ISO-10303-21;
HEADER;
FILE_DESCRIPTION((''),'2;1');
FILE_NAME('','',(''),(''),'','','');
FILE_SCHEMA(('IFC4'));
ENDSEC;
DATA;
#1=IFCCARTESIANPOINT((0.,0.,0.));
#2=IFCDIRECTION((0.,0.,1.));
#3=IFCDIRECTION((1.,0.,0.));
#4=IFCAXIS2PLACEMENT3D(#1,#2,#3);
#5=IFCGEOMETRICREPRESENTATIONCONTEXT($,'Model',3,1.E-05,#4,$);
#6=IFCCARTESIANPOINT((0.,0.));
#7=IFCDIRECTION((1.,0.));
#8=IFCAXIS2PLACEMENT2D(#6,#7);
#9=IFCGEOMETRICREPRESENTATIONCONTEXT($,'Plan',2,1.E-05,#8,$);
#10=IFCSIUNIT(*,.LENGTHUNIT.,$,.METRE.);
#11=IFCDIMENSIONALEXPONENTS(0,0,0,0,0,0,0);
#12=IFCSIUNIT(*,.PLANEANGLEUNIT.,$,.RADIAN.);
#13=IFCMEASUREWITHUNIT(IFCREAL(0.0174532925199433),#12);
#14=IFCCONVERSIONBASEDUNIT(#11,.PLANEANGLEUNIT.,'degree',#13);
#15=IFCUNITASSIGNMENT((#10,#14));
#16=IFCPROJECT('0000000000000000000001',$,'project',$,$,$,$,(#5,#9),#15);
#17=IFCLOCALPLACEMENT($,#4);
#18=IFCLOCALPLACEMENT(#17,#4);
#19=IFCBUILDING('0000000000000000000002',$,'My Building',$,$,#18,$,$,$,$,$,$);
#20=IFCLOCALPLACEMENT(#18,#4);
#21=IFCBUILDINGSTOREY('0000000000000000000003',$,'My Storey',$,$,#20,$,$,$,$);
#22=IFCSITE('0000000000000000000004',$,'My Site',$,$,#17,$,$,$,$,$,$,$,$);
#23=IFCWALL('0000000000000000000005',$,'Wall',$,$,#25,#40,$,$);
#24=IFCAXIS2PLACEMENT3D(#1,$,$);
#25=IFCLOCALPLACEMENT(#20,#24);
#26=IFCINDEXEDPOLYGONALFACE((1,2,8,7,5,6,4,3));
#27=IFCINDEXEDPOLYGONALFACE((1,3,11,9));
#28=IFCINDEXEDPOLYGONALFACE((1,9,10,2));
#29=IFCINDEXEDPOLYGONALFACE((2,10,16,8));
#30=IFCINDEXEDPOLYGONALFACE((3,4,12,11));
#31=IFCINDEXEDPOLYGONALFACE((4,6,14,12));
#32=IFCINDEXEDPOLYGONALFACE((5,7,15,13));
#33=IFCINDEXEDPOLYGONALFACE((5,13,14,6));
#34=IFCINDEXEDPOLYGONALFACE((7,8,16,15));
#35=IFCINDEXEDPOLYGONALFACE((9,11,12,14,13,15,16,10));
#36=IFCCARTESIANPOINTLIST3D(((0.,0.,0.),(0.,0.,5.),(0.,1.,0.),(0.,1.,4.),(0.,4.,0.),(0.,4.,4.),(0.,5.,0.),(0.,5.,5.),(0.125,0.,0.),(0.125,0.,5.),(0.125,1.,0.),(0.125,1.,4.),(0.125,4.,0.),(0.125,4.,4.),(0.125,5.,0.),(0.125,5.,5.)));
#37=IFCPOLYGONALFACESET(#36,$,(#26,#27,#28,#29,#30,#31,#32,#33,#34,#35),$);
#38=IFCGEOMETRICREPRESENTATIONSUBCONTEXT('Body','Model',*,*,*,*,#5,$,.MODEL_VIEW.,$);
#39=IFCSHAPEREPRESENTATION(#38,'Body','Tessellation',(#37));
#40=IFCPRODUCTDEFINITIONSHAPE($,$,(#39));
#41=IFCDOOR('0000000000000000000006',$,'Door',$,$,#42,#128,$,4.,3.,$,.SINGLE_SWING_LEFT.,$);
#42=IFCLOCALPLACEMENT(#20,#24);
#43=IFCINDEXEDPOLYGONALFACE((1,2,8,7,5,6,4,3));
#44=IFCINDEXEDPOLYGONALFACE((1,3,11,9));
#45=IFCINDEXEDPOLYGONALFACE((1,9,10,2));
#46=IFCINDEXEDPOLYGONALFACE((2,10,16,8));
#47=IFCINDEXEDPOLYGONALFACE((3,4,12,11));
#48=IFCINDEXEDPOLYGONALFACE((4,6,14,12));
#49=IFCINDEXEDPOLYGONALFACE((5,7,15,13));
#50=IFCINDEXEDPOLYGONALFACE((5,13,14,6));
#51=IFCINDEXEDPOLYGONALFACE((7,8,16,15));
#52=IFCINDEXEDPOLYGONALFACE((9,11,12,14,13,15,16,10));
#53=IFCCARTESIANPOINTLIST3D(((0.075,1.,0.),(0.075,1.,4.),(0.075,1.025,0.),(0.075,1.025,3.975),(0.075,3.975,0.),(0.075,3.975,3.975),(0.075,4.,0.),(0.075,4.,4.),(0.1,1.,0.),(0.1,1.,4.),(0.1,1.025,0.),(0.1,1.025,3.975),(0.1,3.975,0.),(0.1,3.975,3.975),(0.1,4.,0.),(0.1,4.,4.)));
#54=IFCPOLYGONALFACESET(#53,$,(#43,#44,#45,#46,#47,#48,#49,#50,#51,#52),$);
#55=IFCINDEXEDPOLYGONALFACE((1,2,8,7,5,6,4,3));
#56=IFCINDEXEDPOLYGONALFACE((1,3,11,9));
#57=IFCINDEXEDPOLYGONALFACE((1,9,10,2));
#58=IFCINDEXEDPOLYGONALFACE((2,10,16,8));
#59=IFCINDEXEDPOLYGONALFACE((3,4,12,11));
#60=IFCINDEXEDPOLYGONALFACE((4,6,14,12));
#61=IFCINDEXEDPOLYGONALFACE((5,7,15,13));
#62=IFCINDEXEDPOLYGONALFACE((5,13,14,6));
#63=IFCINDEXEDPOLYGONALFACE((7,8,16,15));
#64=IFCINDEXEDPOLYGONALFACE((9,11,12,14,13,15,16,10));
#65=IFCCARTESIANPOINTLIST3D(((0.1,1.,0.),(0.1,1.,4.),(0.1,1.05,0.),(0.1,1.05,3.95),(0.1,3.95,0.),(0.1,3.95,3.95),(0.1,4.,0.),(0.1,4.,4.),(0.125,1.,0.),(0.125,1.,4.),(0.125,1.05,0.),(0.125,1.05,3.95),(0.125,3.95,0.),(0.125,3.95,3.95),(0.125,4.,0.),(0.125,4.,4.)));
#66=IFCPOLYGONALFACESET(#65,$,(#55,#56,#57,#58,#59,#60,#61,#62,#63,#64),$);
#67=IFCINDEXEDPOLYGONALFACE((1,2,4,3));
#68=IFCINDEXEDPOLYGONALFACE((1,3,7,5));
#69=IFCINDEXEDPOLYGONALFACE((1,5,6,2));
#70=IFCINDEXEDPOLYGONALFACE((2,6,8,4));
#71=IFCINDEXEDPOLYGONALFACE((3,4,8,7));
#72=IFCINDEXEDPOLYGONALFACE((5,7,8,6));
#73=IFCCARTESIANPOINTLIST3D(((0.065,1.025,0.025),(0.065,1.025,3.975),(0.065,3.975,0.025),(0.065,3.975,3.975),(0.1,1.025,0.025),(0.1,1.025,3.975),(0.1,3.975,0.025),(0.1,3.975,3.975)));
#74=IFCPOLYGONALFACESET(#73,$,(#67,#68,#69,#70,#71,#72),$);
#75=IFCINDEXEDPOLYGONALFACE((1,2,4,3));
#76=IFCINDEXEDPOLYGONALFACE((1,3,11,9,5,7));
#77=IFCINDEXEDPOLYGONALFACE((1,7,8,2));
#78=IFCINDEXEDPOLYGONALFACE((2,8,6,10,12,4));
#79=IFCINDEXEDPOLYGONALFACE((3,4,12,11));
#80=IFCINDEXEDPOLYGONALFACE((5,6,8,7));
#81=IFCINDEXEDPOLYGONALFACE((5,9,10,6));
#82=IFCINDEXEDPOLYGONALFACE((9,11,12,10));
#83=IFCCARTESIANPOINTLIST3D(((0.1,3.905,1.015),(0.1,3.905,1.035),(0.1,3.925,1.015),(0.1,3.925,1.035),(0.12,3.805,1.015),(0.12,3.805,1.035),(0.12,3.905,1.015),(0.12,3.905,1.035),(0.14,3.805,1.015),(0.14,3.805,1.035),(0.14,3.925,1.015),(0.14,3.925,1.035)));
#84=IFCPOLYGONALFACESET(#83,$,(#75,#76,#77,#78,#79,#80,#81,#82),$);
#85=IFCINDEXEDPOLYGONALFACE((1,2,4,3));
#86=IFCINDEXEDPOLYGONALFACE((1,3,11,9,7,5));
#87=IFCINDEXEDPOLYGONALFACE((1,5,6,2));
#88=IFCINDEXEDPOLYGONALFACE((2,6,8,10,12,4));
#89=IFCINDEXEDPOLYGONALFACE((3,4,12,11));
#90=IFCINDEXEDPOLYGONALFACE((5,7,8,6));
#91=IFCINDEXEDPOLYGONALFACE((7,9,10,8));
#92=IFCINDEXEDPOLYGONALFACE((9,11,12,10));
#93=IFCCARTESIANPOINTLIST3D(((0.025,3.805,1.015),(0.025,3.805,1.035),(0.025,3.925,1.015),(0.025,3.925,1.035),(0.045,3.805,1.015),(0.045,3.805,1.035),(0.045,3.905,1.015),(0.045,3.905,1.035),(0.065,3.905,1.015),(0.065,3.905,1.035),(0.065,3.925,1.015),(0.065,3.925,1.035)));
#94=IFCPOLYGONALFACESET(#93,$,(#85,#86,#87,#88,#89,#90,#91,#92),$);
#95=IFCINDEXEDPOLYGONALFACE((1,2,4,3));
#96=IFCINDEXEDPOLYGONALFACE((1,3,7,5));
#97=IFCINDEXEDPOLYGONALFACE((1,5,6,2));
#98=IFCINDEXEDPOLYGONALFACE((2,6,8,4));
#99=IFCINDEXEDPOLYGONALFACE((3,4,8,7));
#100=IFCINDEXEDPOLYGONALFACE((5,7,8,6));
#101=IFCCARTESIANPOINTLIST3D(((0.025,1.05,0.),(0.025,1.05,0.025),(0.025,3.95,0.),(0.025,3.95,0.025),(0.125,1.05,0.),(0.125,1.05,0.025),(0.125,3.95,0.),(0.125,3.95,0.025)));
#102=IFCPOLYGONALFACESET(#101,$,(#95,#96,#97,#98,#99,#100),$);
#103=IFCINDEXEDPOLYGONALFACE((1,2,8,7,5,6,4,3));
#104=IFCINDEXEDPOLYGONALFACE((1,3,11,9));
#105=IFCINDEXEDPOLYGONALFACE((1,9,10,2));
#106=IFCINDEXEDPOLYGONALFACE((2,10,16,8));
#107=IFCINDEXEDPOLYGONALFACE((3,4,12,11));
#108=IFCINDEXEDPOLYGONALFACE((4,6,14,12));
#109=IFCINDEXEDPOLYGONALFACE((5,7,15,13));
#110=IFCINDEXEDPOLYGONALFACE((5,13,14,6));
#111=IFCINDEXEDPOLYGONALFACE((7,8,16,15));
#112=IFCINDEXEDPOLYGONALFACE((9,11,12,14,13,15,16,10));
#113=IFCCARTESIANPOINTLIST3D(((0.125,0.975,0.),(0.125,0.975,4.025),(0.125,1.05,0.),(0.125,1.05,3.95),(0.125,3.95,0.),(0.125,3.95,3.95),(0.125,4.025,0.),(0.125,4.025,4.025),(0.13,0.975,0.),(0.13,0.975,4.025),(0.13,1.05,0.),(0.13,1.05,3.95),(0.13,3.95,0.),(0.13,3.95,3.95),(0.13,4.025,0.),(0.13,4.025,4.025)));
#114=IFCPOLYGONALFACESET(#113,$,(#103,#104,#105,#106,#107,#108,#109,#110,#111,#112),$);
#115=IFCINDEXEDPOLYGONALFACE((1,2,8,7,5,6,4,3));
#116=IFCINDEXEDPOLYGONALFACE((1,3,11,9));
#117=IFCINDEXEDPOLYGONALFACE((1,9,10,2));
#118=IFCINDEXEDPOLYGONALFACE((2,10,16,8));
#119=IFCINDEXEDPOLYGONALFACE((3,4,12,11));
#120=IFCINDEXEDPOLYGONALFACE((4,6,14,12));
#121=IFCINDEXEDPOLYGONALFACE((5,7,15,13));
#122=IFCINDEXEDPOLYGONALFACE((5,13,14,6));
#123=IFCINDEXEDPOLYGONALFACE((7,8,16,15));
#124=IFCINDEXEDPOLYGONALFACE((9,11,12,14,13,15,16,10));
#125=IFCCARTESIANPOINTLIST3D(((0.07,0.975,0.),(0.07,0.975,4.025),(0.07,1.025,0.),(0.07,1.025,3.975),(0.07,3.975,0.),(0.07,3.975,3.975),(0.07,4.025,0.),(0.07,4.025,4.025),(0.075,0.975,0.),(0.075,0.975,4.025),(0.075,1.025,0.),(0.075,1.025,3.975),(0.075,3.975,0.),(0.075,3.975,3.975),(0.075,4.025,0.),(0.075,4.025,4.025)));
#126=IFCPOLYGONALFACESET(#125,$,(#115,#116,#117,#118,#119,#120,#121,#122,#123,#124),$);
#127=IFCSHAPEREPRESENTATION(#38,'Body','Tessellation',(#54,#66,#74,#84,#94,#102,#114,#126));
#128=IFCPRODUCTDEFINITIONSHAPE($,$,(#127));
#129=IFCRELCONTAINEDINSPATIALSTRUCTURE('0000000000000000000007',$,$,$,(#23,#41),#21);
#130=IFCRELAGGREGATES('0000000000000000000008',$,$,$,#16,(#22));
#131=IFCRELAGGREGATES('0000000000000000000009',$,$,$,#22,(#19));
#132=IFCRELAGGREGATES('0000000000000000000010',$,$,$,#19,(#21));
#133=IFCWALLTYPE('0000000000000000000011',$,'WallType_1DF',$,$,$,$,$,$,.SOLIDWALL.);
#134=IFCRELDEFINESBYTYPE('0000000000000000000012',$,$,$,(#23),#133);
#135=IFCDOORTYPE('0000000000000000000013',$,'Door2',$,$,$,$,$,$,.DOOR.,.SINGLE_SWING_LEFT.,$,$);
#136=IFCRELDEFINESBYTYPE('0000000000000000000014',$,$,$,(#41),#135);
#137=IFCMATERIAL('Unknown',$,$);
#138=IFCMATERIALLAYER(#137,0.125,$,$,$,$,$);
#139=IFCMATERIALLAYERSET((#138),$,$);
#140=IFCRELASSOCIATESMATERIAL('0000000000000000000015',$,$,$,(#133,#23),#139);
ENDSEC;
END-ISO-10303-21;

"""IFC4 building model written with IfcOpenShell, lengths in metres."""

from ifc_helpers import new_model, entity, si_unit, converted_unit, frame, origin_with_axes, origin_2d_with_axis, place, context, subcontext, project, spatial, line, indexed_curve, outline, extrude, shape, source, transform, mapped, material, layer, layer_set, layer_usage, type_object, type_shapes, element, fill, save


model = new_model("IFC4")

# Units and contexts
model_context = context("Model", 3, precision=1e-05, world=origin_with_axes())
plan_context = context("Plan", 2, precision=1e-05, world=origin_2d_with_axis())
body_context_1 = subcontext(model_context, "Body", "Model", "MODEL_VIEW")
body_context_2 = subcontext(plan_context, "Body", "Plan", "PLAN_VIEW")
ifc_project = project(units=[si_unit("LENGTHUNIT", "METRE"), converted_unit("PLANEANGLEUNIT", "degree", entity("IfcReal", 0.0174532925199433), si_unit("PLANEANGLEUNIT", "RADIAN"), dimensions=[0, 0, 0, 0, 0, 0, 0])], contexts=[model_context, plan_context])

# Site, building, storey
site_placement = place(None, origin_with_axes())
site = spatial("IfcSite", under=ifc_project, at=site_placement, Name="My Site")
building_placement = place(site_placement, origin_with_axes())
building = spatial("IfcBuilding", under=site, at=building_placement, Name="My Building")
storey_placement = place(building_placement, origin_with_axes())
storey = spatial("IfcBuildingStorey", under=building, at=storey_placement, Name="My Storey")

# Wall, opening, door
ifc_material = material(Name="Unknown")
ifc_layer = layer(ifc_material, 0.125)
ifc_layer_set = layer_set([ifc_layer])
ifc_layer_usage_1 = layer_usage(ifc_layer_set, "AXIS2", "POSITIVE", 0.0)
wall_type = type_object("IfcWallType", Name="WallType_1DF", PredefinedType="SOLIDWALL", material=ifc_layer_set)
wall_1_placement = place(storey_placement, frame((0.125, 0.0, 0.0), z_axis=(0.0, 0.0, 1.0), x_axis=(0.0, 1.0, 0.0)))
wall_1 = element("IfcWall", 1, at=wall_1_placement, inside=storey, type_object=wall_type, material=ifc_layer_usage_1, Name="Wall", context=body_context_1, shape_type="SweptSolid", body=[
    extrude(outline(indexed_curve([(0.0, 0.0), (0.0, 0.125), (5.0, 0.125), (5.0, 0.0), (0.0, 0.0)], self_intersect=False)), origin_with_axes(), (0.0, 0.0, 1.0), 5.0),
])
shared_shape_1 = source(origin_with_axes(), body_context_1, "Body", "SweptSolid", [
    extrude(outline(indexed_curve([(0.0, 0.0), (3.0, 0.0), (3.0, 4.0), (0.0, 4.0)], segments=[line(1, 2, 3, 4, 1)])), frame((0.0, -0.1, 0.0), z_axis=(0.0, -1.0, 0.0), x_axis=(1.0, 0.0, 0.0)), (0.0, 0.0, -1.0), 0.45),
])
opening_1_placement = place(wall_1_placement, frame((1.0, 0.0, 0.0), z_axis=(0.0, 0.0, 1.0), x_axis=(1.0, 0.0, 0.0)))
opening_1 = element("IfcOpeningElement", 2, at=opening_1_placement, cuts=wall_1, PredefinedType="OPENING", context=body_context_1, shape_type="MappedRepresentation", body=[
    mapped(shared_shape_1, transform((0.0, 0.0, 0.0), x_axis=(1.0, 0.0, 0.0), y_axis=(0.0, 1.0, 0.0), z_axis=(0.0, 0.0, 1.0), scale=1.0)),
])
door_type = type_object("IfcDoorType", Name="Door2", OperationType="SINGLE_SWING_LEFT", PredefinedType="DOOR")
shared_shape_2 = source(origin_with_axes(), body_context_1, "Body", "SweptSolid", [
    extrude(outline(indexed_curve([(0.0, 0.0), (0.0, 4.0), (3.0, 4.0), (3.0, 0.0), (2.975, 0.0), (2.975, 3.975), (0.025, 3.975), (0.025, 0.0)], segments=[line(1, 2, 3, 4, 5, 6, 7, 8, 1)])), frame((0.0, 0.025, 0.0), z_axis=(0.0, -1.0, 0.0), x_axis=(1.0, 0.0, 0.0)), (0.0, 0.0, -1.0), 0.025),
    extrude(outline(indexed_curve([(0.0, 0.0), (0.0, 4.0), (3.0, 4.0), (3.0, 0.0), (2.95, 0.0), (2.95, 3.95), (0.05, 3.95), (0.05, 0.0)], segments=[line(1, 2, 3, 4, 5, 6, 7, 8, 1)])), frame((0.0, 0.0, 0.0), z_axis=(0.0, -1.0, 0.0), x_axis=(1.0, 0.0, 0.0)), (0.0, 0.0, -1.0), 0.025),
    extrude(outline(indexed_curve([(0.0, 0.0), (2.95, 0.0), (2.95, 0.035), (0.0, 0.035)], segments=[line(1, 2, 3, 4, 1)])), frame((0.025, 0.025, 0.025), z_axis=(0.0, 0.0, 1.0), x_axis=(1.0, 0.0, 0.0)), (0.0, 0.0, 1.0), 3.95),
    extrude(outline(indexed_curve([(0.0, 0.0), (0.0, -0.04), (-0.12, -0.04), (-0.12, -0.02), (-0.02, -0.02), (-0.02, 0.0)], segments=[line(1, 2, 3, 4, 5, 6, 1)])), frame((2.925, 0.025, 1.015), z_axis=(0.0, 0.0, 1.0), x_axis=(1.0, 0.0, 0.0)), (0.0, 0.0, 1.0), 0.02),
    extrude(outline(indexed_curve([(0.0, 0.0), (0.0, 0.04), (-0.12, 0.04), (-0.12, 0.02), (-0.02, 0.02), (-0.02, 0.0)], segments=[line(1, 2, 3, 4, 5, 6, 1)])), frame((2.925, 0.06, 1.015), z_axis=(0.0, 0.0, 1.0), x_axis=(1.0, 0.0, 0.0)), (0.0, 0.0, 1.0), 0.02),
    extrude(outline(indexed_curve([(0.0, 0.0), (2.9, 0.0), (2.9, 0.1), (0.0, 0.1)], segments=[line(1, 2, 3, 4, 1)])), frame((0.05, 0.0, 0.0), z_axis=(0.0, 0.0, 1.0), x_axis=(1.0, 0.0, 0.0)), (0.0, 0.0, 1.0), 0.025),
    extrude(outline(indexed_curve([(0.0, 0.0), (0.0, 4.025), (3.05, 4.025), (3.05, 0.0), (2.975, 0.0), (2.975, 3.95), (0.075, 3.95), (0.075, 0.0)], segments=[line(1, 2, 3, 4, 5, 6, 7, 8, 1)])), frame((-0.025, -0.005, 0.0), z_axis=(0.0, -1.0, 0.0), x_axis=(1.0, 0.0, 0.0)), (0.0, 0.0, -1.0), 0.005),
    extrude(outline(indexed_curve([(0.0, 0.0), (0.0, 4.025), (3.05, 4.025), (3.05, 0.0), (3.0, 0.0), (3.0, 3.975), (0.05, 3.975), (0.05, 0.0)], segments=[line(1, 2, 3, 4, 5, 6, 7, 8, 1)])), frame((-0.025, 0.05, 0.0), z_axis=(0.0, -1.0, 0.0), x_axis=(1.0, 0.0, 0.0)), (0.0, 0.0, -1.0), 0.005),
])
shared_shape_3 = source(origin_with_axes(), body_context_2, "Body", "Curve2D", [
    entity("IfcIndexedPolyCurve", entity("IfcCartesianPointList2D", [[0.0, 0.0], [0.0, 0.05], [0.025, 0.05], [0.025, 0.025], [0.05, 0.025], [0.05, 0.0]]), [entity("IfcLineIndex", [1, 2, 3, 4, 5, 6, 1])]),
    entity("IfcIndexedPolyCurve", entity("IfcCartesianPointList2D", [[3.0, 0.0], [3.0, 0.05], [2.975, 0.05], [2.975, 0.025], [2.95, 0.025], [2.95, 0.0]]), [entity("IfcLineIndex", [1, 2, 3, 4, 5, 6, 1])]),
    entity("IfcTrimmedCurve", entity("IfcEllipse", entity("IfcAxis2Placement2D", entity("IfcCartesianPoint", [0.06, 0.05]), entity("IfcDirection", [1.0, 0.0])), 2.915, 2.95), [entity("IfcCartesianPoint", [2.975, 0.05])], [entity("IfcCartesianPoint", [0.06, 3.0])], True, "CARTESIAN"),
    entity("IfcIndexedPolyCurve", entity("IfcCartesianPointList2D", [[0.025, 0.05], [0.06, 0.05], [0.06, 3.0], [0.025, 3.0]]), [entity("IfcLineIndex", [1, 2, 3, 4, 1])]),
])
type_shapes(door_type, [shared_shape_2, shared_shape_3])
door_placement = place(opening_1_placement, origin_with_axes())
door = element("IfcDoor", 3, at=door_placement, inside=storey, type_object=door_type, Name="Door", OperationType="SINGLE_SWING_LEFT", OverallHeight=4.0, OverallWidth=3.0, shapes=[
    shape(body_context_1, "Body", "MappedRepresentation", [mapped(shared_shape_2, transform((0.0, 0.0, 0.0), x_axis=(1.0, 0.0, 0.0), y_axis=(0.0, 1.0, 0.0), z_axis=(0.0, 0.0, 1.0), scale=1.0))]),
    shape(body_context_2, "Body", "MappedRepresentation", [mapped(shared_shape_3, transform((0.0, 0.0, 0.0), x_axis=(1.0, 0.0, 0.0), y_axis=(0.0, 1.0, 0.0), z_axis=(0.0, 0.0, 1.0), scale=1.0))]),
])
fill(opening_1, door)

save(model, "model.ifc")
